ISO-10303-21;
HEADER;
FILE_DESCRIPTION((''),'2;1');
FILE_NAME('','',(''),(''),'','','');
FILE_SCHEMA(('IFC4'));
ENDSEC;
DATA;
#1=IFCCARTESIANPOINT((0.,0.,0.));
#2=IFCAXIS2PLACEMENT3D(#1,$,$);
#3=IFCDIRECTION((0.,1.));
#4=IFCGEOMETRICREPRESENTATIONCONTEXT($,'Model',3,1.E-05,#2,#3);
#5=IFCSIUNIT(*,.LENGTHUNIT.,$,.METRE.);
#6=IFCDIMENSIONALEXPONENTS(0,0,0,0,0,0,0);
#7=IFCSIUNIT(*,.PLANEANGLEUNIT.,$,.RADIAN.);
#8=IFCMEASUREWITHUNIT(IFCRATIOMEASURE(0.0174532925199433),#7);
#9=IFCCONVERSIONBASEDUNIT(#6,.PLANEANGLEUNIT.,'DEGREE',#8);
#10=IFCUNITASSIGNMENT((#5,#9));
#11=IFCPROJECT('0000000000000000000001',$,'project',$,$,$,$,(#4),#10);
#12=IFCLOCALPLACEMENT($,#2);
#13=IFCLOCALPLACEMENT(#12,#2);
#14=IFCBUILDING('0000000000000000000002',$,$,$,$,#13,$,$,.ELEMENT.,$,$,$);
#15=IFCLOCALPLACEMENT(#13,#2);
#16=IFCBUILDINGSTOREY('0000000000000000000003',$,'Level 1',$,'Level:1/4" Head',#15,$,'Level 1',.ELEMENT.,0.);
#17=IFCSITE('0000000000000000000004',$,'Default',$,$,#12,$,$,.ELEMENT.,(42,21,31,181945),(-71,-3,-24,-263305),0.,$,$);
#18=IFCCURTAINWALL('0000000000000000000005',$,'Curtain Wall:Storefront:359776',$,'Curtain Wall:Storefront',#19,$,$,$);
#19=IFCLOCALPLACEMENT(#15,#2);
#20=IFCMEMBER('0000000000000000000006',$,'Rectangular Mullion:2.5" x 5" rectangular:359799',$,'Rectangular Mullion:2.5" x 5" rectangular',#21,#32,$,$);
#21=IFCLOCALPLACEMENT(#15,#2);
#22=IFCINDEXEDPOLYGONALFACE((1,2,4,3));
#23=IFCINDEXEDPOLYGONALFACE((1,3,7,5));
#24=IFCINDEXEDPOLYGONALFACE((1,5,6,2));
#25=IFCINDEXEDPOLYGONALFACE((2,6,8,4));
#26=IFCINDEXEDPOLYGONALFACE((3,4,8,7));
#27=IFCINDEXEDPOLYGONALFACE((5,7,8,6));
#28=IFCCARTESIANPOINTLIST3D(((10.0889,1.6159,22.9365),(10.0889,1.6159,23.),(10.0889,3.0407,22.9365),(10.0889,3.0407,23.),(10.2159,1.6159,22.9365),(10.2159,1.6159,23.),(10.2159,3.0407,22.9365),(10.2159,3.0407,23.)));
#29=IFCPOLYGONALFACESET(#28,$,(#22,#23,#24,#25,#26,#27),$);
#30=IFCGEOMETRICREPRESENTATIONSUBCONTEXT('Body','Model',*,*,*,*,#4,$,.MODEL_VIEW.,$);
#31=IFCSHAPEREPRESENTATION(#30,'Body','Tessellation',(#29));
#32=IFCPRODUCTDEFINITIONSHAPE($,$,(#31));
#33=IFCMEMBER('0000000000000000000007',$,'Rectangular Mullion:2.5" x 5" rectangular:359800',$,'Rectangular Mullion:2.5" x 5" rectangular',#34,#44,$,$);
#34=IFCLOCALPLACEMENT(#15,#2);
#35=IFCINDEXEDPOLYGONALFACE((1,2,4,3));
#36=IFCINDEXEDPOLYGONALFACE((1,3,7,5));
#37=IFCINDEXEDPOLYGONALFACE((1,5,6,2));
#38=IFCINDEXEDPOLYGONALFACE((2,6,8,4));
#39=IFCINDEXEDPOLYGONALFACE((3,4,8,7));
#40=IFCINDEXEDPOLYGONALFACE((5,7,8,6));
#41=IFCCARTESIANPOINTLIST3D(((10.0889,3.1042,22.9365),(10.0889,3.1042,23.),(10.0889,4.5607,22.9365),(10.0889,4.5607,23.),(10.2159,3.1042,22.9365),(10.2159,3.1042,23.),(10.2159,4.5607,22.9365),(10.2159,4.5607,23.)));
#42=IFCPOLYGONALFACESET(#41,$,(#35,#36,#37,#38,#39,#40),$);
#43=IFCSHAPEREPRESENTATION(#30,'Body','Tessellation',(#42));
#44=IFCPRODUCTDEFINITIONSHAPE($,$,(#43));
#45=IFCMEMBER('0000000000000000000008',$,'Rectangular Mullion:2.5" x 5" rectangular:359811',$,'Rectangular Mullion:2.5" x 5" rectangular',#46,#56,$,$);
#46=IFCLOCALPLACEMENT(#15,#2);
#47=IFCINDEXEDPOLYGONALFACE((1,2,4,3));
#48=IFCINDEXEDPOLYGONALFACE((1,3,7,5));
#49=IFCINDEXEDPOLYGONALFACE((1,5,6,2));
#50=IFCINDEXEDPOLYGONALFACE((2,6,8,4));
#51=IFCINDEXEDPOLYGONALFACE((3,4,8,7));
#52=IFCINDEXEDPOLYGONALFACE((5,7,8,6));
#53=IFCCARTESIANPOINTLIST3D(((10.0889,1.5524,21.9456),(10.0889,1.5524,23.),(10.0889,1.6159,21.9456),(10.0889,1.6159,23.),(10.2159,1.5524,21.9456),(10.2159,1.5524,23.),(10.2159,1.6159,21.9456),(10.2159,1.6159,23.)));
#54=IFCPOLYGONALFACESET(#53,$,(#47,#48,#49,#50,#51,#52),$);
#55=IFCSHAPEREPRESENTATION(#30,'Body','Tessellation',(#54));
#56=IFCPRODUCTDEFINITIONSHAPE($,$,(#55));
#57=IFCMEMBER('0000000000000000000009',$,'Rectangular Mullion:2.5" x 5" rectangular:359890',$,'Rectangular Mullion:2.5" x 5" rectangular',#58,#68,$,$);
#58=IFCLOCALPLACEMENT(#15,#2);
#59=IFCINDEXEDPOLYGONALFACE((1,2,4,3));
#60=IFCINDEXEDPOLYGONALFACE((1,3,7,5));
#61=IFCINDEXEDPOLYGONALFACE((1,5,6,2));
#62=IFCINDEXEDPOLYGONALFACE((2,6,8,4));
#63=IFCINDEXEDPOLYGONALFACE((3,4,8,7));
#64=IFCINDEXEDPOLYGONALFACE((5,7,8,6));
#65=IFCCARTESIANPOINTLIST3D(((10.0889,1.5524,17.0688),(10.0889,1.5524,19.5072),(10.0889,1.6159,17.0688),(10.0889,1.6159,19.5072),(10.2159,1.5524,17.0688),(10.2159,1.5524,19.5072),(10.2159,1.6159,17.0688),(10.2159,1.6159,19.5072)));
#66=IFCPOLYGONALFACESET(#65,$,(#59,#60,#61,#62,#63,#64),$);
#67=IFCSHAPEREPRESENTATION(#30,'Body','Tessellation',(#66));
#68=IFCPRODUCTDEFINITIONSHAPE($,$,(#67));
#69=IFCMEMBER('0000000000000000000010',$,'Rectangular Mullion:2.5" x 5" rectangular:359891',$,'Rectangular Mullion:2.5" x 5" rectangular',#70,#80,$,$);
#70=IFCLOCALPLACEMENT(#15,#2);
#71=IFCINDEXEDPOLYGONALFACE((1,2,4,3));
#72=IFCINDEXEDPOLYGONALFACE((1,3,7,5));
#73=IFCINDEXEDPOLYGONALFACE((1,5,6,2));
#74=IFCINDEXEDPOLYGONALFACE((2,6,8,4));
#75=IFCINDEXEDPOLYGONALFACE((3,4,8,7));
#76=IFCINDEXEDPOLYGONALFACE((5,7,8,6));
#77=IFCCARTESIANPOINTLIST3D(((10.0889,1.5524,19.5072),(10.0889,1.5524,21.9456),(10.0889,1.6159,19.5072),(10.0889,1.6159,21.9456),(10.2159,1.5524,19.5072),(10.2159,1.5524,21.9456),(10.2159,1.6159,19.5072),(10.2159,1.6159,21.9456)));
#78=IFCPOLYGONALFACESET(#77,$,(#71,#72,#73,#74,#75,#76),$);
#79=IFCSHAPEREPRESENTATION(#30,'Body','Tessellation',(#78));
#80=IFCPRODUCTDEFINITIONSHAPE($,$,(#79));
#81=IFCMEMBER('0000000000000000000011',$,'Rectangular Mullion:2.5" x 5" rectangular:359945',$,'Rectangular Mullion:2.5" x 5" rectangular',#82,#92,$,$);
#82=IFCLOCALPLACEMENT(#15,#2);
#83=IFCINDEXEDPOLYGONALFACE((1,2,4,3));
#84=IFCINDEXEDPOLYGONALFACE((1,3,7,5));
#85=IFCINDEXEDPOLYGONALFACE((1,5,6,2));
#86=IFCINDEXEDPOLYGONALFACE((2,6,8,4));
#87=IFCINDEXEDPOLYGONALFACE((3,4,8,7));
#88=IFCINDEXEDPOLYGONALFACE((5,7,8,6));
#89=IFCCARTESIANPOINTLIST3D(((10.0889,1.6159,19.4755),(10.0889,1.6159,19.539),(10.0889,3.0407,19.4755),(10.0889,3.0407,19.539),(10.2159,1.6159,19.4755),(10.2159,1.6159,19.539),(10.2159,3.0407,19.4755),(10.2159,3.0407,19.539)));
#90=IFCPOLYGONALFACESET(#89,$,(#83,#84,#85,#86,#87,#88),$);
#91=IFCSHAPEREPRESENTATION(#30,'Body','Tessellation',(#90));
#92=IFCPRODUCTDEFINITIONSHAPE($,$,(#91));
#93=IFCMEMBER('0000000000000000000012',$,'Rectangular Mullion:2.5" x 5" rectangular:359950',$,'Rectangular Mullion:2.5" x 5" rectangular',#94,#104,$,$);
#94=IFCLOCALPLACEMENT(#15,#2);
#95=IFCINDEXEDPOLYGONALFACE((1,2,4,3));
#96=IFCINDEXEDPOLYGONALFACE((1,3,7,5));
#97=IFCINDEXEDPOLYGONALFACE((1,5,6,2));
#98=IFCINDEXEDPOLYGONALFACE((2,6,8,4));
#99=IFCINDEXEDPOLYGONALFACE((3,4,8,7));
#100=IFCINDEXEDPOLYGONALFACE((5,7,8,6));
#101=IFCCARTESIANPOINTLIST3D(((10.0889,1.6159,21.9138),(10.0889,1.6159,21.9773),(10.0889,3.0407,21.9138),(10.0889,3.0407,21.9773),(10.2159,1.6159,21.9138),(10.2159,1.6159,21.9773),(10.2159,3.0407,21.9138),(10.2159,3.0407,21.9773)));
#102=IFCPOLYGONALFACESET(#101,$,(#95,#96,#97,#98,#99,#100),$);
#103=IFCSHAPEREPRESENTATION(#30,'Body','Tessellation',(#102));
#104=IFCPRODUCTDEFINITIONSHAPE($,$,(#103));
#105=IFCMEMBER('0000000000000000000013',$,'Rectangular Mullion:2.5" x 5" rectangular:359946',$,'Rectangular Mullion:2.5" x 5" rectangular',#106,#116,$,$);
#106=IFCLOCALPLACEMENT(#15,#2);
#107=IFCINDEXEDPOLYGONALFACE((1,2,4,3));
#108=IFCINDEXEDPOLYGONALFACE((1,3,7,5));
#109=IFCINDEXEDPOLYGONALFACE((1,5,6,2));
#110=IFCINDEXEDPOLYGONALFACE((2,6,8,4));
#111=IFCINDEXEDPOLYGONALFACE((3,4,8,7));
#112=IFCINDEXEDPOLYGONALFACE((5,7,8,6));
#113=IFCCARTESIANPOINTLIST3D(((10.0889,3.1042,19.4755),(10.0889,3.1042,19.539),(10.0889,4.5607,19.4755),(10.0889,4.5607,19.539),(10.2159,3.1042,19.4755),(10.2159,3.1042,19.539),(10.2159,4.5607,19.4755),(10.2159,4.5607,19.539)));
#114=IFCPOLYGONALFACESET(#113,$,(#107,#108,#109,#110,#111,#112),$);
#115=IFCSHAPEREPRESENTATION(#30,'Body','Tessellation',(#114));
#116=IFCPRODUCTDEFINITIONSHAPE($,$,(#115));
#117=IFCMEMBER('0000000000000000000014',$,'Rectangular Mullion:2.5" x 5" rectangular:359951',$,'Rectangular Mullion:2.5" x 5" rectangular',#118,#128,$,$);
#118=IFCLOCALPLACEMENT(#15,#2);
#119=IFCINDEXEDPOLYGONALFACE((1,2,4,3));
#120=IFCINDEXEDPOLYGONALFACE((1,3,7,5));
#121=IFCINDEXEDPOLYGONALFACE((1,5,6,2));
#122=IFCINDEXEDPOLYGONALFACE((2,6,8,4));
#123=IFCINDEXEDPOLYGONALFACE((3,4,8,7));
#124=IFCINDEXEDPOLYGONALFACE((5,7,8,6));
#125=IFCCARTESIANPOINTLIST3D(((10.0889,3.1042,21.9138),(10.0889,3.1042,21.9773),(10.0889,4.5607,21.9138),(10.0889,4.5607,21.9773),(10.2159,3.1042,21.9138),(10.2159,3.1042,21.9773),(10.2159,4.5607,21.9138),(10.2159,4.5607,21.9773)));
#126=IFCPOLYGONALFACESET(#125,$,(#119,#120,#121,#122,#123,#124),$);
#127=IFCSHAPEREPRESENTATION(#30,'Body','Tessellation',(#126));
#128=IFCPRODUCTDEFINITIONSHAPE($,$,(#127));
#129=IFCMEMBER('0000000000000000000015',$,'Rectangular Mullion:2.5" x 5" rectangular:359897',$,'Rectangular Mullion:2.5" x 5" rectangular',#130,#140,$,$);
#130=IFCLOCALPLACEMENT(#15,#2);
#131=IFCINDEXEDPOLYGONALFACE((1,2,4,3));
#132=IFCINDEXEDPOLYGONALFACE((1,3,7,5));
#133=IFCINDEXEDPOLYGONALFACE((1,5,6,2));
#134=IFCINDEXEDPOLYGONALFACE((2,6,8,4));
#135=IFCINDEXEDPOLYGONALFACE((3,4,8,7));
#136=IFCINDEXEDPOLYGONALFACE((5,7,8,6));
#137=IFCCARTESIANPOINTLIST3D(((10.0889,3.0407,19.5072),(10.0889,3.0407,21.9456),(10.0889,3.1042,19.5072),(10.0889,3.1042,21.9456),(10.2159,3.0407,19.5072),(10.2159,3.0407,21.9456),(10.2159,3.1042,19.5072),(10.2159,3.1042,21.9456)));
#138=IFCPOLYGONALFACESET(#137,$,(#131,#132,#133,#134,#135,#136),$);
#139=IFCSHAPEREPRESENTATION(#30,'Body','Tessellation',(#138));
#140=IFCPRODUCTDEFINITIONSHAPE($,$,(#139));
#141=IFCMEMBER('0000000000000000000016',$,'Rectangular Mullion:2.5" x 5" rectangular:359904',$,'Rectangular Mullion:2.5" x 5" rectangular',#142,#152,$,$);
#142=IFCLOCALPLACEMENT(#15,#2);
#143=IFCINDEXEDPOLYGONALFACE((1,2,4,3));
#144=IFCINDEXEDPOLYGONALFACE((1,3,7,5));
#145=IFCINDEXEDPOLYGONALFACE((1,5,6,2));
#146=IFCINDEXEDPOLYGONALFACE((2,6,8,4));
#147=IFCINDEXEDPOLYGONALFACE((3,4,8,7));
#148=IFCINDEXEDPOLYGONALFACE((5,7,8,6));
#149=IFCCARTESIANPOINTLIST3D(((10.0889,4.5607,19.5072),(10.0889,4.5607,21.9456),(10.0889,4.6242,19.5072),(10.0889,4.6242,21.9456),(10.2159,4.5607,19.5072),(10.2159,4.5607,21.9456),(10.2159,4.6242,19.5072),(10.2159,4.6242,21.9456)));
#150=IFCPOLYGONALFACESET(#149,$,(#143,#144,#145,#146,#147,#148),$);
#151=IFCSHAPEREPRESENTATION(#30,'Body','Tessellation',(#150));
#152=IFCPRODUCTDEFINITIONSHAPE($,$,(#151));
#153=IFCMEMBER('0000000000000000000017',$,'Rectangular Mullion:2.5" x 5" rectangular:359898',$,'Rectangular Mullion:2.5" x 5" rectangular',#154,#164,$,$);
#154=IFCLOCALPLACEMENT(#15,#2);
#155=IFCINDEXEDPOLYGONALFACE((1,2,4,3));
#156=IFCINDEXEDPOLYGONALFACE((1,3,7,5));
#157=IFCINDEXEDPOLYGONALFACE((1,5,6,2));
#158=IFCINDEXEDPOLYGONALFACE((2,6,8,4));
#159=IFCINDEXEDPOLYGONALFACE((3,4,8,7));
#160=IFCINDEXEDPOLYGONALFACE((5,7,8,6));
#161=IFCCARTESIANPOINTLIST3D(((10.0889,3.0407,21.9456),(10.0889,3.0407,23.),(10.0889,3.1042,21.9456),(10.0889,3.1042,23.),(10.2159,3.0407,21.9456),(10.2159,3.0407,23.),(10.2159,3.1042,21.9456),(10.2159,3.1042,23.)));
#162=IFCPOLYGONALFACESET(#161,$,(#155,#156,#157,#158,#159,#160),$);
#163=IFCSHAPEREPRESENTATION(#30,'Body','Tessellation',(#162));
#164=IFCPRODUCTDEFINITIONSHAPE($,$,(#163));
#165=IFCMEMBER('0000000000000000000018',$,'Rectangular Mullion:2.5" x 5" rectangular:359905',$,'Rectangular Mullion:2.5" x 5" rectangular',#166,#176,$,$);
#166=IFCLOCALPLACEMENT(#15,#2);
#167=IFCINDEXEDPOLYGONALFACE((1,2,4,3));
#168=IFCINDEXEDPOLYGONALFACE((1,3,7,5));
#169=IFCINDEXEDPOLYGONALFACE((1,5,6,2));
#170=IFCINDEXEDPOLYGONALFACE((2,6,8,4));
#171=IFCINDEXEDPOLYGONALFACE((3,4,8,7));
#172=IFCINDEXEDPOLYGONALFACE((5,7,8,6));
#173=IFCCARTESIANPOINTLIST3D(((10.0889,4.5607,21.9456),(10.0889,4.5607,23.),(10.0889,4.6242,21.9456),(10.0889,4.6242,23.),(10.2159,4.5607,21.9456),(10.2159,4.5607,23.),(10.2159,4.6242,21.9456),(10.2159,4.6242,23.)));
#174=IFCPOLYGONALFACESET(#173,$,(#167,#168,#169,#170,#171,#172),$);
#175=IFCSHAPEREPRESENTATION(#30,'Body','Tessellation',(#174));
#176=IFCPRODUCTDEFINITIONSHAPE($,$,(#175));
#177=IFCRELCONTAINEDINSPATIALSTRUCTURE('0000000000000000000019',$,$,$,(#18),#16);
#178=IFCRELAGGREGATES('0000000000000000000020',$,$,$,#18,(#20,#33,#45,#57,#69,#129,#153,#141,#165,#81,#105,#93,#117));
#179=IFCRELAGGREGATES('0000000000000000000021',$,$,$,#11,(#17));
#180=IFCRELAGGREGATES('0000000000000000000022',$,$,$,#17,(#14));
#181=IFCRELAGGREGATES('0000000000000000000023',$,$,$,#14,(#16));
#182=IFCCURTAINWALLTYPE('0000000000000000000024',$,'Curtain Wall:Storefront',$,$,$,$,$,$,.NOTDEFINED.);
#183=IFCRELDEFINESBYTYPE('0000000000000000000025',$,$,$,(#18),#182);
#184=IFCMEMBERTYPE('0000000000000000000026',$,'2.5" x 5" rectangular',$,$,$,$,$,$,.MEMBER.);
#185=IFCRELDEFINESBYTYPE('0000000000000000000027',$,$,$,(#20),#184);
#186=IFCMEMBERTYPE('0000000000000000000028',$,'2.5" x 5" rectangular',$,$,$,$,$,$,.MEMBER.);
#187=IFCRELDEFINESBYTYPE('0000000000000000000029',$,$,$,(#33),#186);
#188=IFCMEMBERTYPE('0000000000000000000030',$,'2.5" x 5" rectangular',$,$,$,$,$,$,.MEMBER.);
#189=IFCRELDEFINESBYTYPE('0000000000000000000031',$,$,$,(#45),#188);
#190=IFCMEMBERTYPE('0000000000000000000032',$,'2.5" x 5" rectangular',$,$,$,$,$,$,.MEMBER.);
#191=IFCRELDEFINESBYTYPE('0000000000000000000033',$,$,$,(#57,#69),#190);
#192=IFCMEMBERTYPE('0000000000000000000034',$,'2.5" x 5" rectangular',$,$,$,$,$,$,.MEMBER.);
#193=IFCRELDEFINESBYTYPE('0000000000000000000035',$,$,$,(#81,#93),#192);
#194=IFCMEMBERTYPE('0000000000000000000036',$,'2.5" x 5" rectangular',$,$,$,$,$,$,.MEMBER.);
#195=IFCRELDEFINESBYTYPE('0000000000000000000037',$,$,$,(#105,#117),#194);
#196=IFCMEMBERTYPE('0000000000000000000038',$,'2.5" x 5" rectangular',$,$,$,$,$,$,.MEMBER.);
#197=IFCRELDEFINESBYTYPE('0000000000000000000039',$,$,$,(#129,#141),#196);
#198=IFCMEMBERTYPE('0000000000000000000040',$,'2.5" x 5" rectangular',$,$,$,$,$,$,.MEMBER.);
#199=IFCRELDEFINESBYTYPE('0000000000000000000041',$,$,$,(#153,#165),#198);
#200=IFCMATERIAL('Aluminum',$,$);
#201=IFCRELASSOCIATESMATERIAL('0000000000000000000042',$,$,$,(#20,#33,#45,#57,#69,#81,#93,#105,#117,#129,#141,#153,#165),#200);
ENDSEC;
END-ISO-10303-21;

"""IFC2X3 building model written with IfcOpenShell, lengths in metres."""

from ifc_helpers import new_model, entity, si_unit, converted_unit, direction, frame, origin, origin_2d_with_axis, place, context, subcontext, project, spatial, rectangle, extrude, source, transform, mapped, material, type_object, type_shapes, element, aggregate, save


model = new_model("IFC2X3")

# Units and contexts
model_context = context("Model", 3, precision=1e-05, world=origin(), true_north=direction((0.0, 1.0)))
body_context = subcontext(model_context, "Body", "Model", "MODEL_VIEW")
ifc_project = project(units=[si_unit("LENGTHUNIT", "METRE"), converted_unit("PLANEANGLEUNIT", "DEGREE", entity("IfcRatioMeasure", 0.0174532925199433), si_unit("PLANEANGLEUNIT", "RADIAN"), dimensions=[0, 0, 0, 0, 0, 0, 0])], contexts=[model_context])

# Site, building, storey
site_placement = place(None, origin())
site = spatial("IfcSite", under=ifc_project, at=site_placement, Name="Default", CompositionType="ELEMENT", RefLatitude=(42, 21, 31, 181945), RefLongitude=(-71, -3, -24, -263305), RefElevation=0.0)
building_placement = place(site_placement, origin())
building = spatial("IfcBuilding", under=site, at=building_placement, CompositionType="ELEMENT")
storey_placement = place(building_placement, origin())
storey = spatial("IfcBuildingStorey", under=building, at=storey_placement, Name="Level 1", ObjectType="Level:1/4\" Head", LongName="Level 1", CompositionType="ELEMENT", Elevation=0.0)

# Curtain wall, members
curtain_wall_type = type_object("IfcCurtainWallType", Name="Curtain Wall:Storefront", PredefinedType="NOTDEFINED")
curtain_wall_placement = place(storey_placement, origin())
curtain_wall = element("IfcCurtainWall", 1, at=curtain_wall_placement, inside=storey, type_object=curtain_wall_type, Name="Curtain Wall:Storefront:359776", ObjectType="Curtain Wall:Storefront")
ifc_material_1 = material(Name="Aluminum")
member_type_1 = type_object("IfcMemberType", Name="2.5\" x 5\" rectangular", PredefinedType="MEMBER")
shared_shape_1 = source(origin(), body_context, "Body", "SweptSolid", [
    extrude(rectangle(XDim=0.127, YDim=0.0635, at=origin_2d_with_axis()), frame((-0.0318, 0.0, -1.4248), z_axis=(0.0, 0.0, 1.0), x_axis=(0.0, -1.0, 0.0)), (0.0, 0.0, 1.0), 1.4248),
])
type_shapes(member_type_1, [shared_shape_1])
member_1_placement = place(storey_placement, frame((10.1524, 3.0407, 23.0), z_axis=(0.0, 1.0, 0.0), x_axis=(0.0, 0.0, 1.0)))
member_1 = element("IfcMember", 2, at=member_1_placement, type_object=member_type_1, material=ifc_material_1, Name="Rectangular Mullion:2.5\" x 5\" rectangular:359799", ObjectType="Rectangular Mullion:2.5\" x 5\" rectangular", context=body_context, shape_type="MappedRepresentation", body=[
    mapped(shared_shape_1, transform((0.0, 0.0, 0.0), scale=1.0)),
])
member_type_2 = type_object("IfcMemberType", Name="2.5\" x 5\" rectangular", PredefinedType="MEMBER")
shared_shape_2 = source(origin(), body_context, "Body", "SweptSolid", [
    extrude(rectangle(XDim=0.127, YDim=0.0635, at=origin_2d_with_axis()), frame((-0.0318, 0.0, -1.4565), z_axis=(0.0, 0.0, 1.0), x_axis=(0.0, -1.0, 0.0)), (0.0, 0.0, 1.0), 1.4565),
])
type_shapes(member_type_2, [shared_shape_2])
member_2_placement = place(storey_placement, frame((10.1524, 4.5607, 23.0), z_axis=(0.0, 1.0, 0.0), x_axis=(0.0, 0.0, 1.0)))
member_2 = element("IfcMember", 3, at=member_2_placement, type_object=member_type_2, material=ifc_material_1, Name="Rectangular Mullion:2.5\" x 5\" rectangular:359800", ObjectType="Rectangular Mullion:2.5\" x 5\" rectangular", context=body_context, shape_type="MappedRepresentation", body=[
    mapped(shared_shape_2, transform((0.0, 0.0, 0.0), scale=1.0)),
])
member_type_3 = type_object("IfcMemberType", Name="2.5\" x 5\" rectangular", PredefinedType="MEMBER")
shared_shape_3 = source(origin(), body_context, "Body", "SweptSolid", [
    extrude(rectangle(XDim=0.127, YDim=0.0635, at=origin_2d_with_axis()), frame((-0.0318, 0.0, -1.0544), z_axis=(0.0, 0.0, 1.0), x_axis=(0.0, -1.0, 0.0)), (0.0, 0.0, 1.0), 1.0544),
])
type_shapes(member_type_3, [shared_shape_3])
member_3_placement = place(storey_placement, frame((10.1524, 1.5524, 23.0), z_axis=(0.0, 0.0, 1.0), x_axis=(0.0, -1.0, 0.0)))
member_3 = element("IfcMember", 4, at=member_3_placement, type_object=member_type_3, material=ifc_material_1, Name="Rectangular Mullion:2.5\" x 5\" rectangular:359811", ObjectType="Rectangular Mullion:2.5\" x 5\" rectangular", context=body_context, shape_type="MappedRepresentation", body=[
    mapped(shared_shape_3, transform((0.0, 0.0, 0.0), scale=1.0)),
])
member_type_4 = type_object("IfcMemberType", Name="2.5\" x 5\" rectangular", PredefinedType="MEMBER")
shared_shape_4 = source(origin(), body_context, "Body", "SweptSolid", [
    extrude(rectangle(XDim=0.127, YDim=0.0635, at=origin_2d_with_axis()), frame((-0.0318, 0.0, -2.4384), z_axis=(0.0, 0.0, 1.0), x_axis=(0.0, -1.0, 0.0)), (0.0, 0.0, 1.0), 2.4384),
])
type_shapes(member_type_4, [shared_shape_4])
member_4_placement = place(storey_placement, frame((10.1524, 1.5524, 19.5072), z_axis=(0.0, 0.0, 1.0), x_axis=(0.0, -1.0, 0.0)))
member_4 = element("IfcMember", 5, at=member_4_placement, type_object=member_type_4, material=ifc_material_1, Name="Rectangular Mullion:2.5\" x 5\" rectangular:359890", ObjectType="Rectangular Mullion:2.5\" x 5\" rectangular", context=body_context, shape_type="MappedRepresentation", body=[
    mapped(shared_shape_4, transform((0.0, 0.0, 0.0), scale=1.0)),
])
member_5_placement = place(storey_placement, frame((10.1524, 1.5524, 21.9456), z_axis=(0.0, 0.0, 1.0), x_axis=(0.0, -1.0, 0.0)))
member_5 = element("IfcMember", 6, at=member_5_placement, type_object=member_type_4, material=ifc_material_1, Name="Rectangular Mullion:2.5\" x 5\" rectangular:359891", ObjectType="Rectangular Mullion:2.5\" x 5\" rectangular", context=body_context, shape_type="MappedRepresentation", body=[
    mapped(shared_shape_4, transform((0.0, 0.0, 0.0), scale=1.0)),
])
member_type_5 = type_object("IfcMemberType", Name="2.5\" x 5\" rectangular", PredefinedType="MEMBER")
shared_shape_5 = source(origin(), body_context, "Body", "SweptSolid", [
    extrude(rectangle(XDim=0.127, YDim=0.0635, at=origin_2d_with_axis()), frame((0.0, 0.0, -1.4248), z_axis=(0.0, 0.0, 1.0), x_axis=(0.0, -1.0, 0.0)), (0.0, 0.0, 1.0), 1.4248),
])
type_shapes(member_type_5, [shared_shape_5])
member_6_placement = place(storey_placement, frame((10.1524, 3.0407, 19.5072), z_axis=(0.0, 1.0, 0.0), x_axis=(0.0, 0.0, 1.0)))
member_6 = element("IfcMember", 7, at=member_6_placement, type_object=member_type_5, material=ifc_material_1, Name="Rectangular Mullion:2.5\" x 5\" rectangular:359945", ObjectType="Rectangular Mullion:2.5\" x 5\" rectangular", context=body_context, shape_type="MappedRepresentation", body=[
    mapped(shared_shape_5, transform((0.0, 0.0, 0.0), scale=1.0)),
])
member_7_placement = place(storey_placement, frame((10.1524, 3.0407, 21.9456), z_axis=(0.0, 1.0, 0.0), x_axis=(0.0, 0.0, 1.0)))
member_7 = element("IfcMember", 8, at=member_7_placement, type_object=member_type_5, material=ifc_material_1, Name="Rectangular Mullion:2.5\" x 5\" rectangular:359950", ObjectType="Rectangular Mullion:2.5\" x 5\" rectangular", context=body_context, shape_type="MappedRepresentation", body=[
    mapped(shared_shape_5, transform((0.0, 0.0, 0.0), scale=1.0)),
])
member_type_6 = type_object("IfcMemberType", Name="2.5\" x 5\" rectangular", PredefinedType="MEMBER")
shared_shape_6 = source(origin(), body_context, "Body", "SweptSolid", [
    extrude(rectangle(XDim=0.127, YDim=0.0635, at=origin_2d_with_axis()), frame((0.0, 0.0, -1.4565), z_axis=(0.0, 0.0, 1.0), x_axis=(0.0, -1.0, 0.0)), (0.0, 0.0, 1.0), 1.4565),
])
type_shapes(member_type_6, [shared_shape_6])
member_8_placement = place(storey_placement, frame((10.1524, 4.5607, 19.5072), z_axis=(0.0, 1.0, 0.0), x_axis=(0.0, 0.0, 1.0)))
member_8 = element("IfcMember", 9, at=member_8_placement, type_object=member_type_6, material=ifc_material_1, Name="Rectangular Mullion:2.5\" x 5\" rectangular:359946", ObjectType="Rectangular Mullion:2.5\" x 5\" rectangular", context=body_context, shape_type="MappedRepresentation", body=[
    mapped(shared_shape_6, transform((0.0, 0.0, 0.0), scale=1.0)),
])
member_9_placement = place(storey_placement, frame((10.1524, 4.5607, 21.9456), z_axis=(0.0, 1.0, 0.0), x_axis=(0.0, 0.0, 1.0)))
member_9 = element("IfcMember", 10, at=member_9_placement, type_object=member_type_6, material=ifc_material_1, Name="Rectangular Mullion:2.5\" x 5\" rectangular:359951", ObjectType="Rectangular Mullion:2.5\" x 5\" rectangular", context=body_context, shape_type="MappedRepresentation", body=[
    mapped(shared_shape_6, transform((0.0, 0.0, 0.0), scale=1.0)),
])
member_type_7 = type_object("IfcMemberType", Name="2.5\" x 5\" rectangular", PredefinedType="MEMBER")
shared_shape_7 = source(origin(), body_context, "Body", "SweptSolid", [
    extrude(rectangle(XDim=0.127, YDim=0.0635, at=origin_2d_with_axis()), frame((0.0, 0.0, -2.4384), z_axis=(0.0, 0.0, 1.0), x_axis=(0.0, -1.0, 0.0)), (0.0, 0.0, 1.0), 2.4384),
])
type_shapes(member_type_7, [shared_shape_7])
member_10_placement = place(storey_placement, frame((10.1524, 3.0724, 19.5072), z_axis=(0.0, 0.0, -1.0), x_axis=(0.0, 1.0, 0.0)))
member_10 = element("IfcMember", 11, at=member_10_placement, type_object=member_type_7, material=ifc_material_1, Name="Rectangular Mullion:2.5\" x 5\" rectangular:359897", ObjectType="Rectangular Mullion:2.5\" x 5\" rectangular", context=body_context, shape_type="MappedRepresentation", body=[
    mapped(shared_shape_7, transform((0.0, 0.0, 0.0), scale=1.0)),
])
member_11_placement = place(storey_placement, frame((10.1524, 4.5924, 19.5072), z_axis=(0.0, 0.0, -1.0), x_axis=(0.0, 1.0, 0.0)))
member_11 = element("IfcMember", 12, at=member_11_placement, type_object=member_type_7, material=ifc_material_1, Name="Rectangular Mullion:2.5\" x 5\" rectangular:359904", ObjectType="Rectangular Mullion:2.5\" x 5\" rectangular", context=body_context, shape_type="MappedRepresentation", body=[
    mapped(shared_shape_7, transform((0.0, 0.0, 0.0), scale=1.0)),
])
member_type_8 = type_object("IfcMemberType", Name="2.5\" x 5\" rectangular", PredefinedType="MEMBER")
shared_shape_8 = source(origin(), body_context, "Body", "SweptSolid", [
    extrude(rectangle(XDim=0.127, YDim=0.0635, at=origin_2d_with_axis()), frame((0.0, 0.0, -1.0544), z_axis=(0.0, 0.0, 1.0), x_axis=(0.0, -1.0, 0.0)), (0.0, 0.0, 1.0), 1.0544),
])
type_shapes(member_type_8, [shared_shape_8])
member_12_placement = place(storey_placement, frame((10.1524, 3.0724, 21.9456), z_axis=(0.0, 0.0, -1.0), x_axis=(0.0, 1.0, 0.0)))
member_12 = element("IfcMember", 13, at=member_12_placement, type_object=member_type_8, material=ifc_material_1, Name="Rectangular Mullion:2.5\" x 5\" rectangular:359898", ObjectType="Rectangular Mullion:2.5\" x 5\" rectangular", context=body_context, shape_type="MappedRepresentation", body=[
    mapped(shared_shape_8, transform((0.0, 0.0, 0.0), scale=1.0)),
])
member_13_placement = place(storey_placement, frame((10.1524, 4.5924, 21.9456), z_axis=(0.0, 0.0, -1.0), x_axis=(0.0, 1.0, 0.0)))
member_13 = element("IfcMember", 14, at=member_13_placement, type_object=member_type_8, material=ifc_material_1, Name="Rectangular Mullion:2.5\" x 5\" rectangular:359905", ObjectType="Rectangular Mullion:2.5\" x 5\" rectangular", context=body_context, shape_type="MappedRepresentation", body=[
    mapped(shared_shape_8, transform((0.0, 0.0, 0.0), scale=1.0)),
])
aggregate(curtain_wall, [member_1, member_2, member_3, member_4, member_5, member_10, member_12, member_11, member_13, member_6, member_8, member_7, member_9])

save(model, "model.ifc")
